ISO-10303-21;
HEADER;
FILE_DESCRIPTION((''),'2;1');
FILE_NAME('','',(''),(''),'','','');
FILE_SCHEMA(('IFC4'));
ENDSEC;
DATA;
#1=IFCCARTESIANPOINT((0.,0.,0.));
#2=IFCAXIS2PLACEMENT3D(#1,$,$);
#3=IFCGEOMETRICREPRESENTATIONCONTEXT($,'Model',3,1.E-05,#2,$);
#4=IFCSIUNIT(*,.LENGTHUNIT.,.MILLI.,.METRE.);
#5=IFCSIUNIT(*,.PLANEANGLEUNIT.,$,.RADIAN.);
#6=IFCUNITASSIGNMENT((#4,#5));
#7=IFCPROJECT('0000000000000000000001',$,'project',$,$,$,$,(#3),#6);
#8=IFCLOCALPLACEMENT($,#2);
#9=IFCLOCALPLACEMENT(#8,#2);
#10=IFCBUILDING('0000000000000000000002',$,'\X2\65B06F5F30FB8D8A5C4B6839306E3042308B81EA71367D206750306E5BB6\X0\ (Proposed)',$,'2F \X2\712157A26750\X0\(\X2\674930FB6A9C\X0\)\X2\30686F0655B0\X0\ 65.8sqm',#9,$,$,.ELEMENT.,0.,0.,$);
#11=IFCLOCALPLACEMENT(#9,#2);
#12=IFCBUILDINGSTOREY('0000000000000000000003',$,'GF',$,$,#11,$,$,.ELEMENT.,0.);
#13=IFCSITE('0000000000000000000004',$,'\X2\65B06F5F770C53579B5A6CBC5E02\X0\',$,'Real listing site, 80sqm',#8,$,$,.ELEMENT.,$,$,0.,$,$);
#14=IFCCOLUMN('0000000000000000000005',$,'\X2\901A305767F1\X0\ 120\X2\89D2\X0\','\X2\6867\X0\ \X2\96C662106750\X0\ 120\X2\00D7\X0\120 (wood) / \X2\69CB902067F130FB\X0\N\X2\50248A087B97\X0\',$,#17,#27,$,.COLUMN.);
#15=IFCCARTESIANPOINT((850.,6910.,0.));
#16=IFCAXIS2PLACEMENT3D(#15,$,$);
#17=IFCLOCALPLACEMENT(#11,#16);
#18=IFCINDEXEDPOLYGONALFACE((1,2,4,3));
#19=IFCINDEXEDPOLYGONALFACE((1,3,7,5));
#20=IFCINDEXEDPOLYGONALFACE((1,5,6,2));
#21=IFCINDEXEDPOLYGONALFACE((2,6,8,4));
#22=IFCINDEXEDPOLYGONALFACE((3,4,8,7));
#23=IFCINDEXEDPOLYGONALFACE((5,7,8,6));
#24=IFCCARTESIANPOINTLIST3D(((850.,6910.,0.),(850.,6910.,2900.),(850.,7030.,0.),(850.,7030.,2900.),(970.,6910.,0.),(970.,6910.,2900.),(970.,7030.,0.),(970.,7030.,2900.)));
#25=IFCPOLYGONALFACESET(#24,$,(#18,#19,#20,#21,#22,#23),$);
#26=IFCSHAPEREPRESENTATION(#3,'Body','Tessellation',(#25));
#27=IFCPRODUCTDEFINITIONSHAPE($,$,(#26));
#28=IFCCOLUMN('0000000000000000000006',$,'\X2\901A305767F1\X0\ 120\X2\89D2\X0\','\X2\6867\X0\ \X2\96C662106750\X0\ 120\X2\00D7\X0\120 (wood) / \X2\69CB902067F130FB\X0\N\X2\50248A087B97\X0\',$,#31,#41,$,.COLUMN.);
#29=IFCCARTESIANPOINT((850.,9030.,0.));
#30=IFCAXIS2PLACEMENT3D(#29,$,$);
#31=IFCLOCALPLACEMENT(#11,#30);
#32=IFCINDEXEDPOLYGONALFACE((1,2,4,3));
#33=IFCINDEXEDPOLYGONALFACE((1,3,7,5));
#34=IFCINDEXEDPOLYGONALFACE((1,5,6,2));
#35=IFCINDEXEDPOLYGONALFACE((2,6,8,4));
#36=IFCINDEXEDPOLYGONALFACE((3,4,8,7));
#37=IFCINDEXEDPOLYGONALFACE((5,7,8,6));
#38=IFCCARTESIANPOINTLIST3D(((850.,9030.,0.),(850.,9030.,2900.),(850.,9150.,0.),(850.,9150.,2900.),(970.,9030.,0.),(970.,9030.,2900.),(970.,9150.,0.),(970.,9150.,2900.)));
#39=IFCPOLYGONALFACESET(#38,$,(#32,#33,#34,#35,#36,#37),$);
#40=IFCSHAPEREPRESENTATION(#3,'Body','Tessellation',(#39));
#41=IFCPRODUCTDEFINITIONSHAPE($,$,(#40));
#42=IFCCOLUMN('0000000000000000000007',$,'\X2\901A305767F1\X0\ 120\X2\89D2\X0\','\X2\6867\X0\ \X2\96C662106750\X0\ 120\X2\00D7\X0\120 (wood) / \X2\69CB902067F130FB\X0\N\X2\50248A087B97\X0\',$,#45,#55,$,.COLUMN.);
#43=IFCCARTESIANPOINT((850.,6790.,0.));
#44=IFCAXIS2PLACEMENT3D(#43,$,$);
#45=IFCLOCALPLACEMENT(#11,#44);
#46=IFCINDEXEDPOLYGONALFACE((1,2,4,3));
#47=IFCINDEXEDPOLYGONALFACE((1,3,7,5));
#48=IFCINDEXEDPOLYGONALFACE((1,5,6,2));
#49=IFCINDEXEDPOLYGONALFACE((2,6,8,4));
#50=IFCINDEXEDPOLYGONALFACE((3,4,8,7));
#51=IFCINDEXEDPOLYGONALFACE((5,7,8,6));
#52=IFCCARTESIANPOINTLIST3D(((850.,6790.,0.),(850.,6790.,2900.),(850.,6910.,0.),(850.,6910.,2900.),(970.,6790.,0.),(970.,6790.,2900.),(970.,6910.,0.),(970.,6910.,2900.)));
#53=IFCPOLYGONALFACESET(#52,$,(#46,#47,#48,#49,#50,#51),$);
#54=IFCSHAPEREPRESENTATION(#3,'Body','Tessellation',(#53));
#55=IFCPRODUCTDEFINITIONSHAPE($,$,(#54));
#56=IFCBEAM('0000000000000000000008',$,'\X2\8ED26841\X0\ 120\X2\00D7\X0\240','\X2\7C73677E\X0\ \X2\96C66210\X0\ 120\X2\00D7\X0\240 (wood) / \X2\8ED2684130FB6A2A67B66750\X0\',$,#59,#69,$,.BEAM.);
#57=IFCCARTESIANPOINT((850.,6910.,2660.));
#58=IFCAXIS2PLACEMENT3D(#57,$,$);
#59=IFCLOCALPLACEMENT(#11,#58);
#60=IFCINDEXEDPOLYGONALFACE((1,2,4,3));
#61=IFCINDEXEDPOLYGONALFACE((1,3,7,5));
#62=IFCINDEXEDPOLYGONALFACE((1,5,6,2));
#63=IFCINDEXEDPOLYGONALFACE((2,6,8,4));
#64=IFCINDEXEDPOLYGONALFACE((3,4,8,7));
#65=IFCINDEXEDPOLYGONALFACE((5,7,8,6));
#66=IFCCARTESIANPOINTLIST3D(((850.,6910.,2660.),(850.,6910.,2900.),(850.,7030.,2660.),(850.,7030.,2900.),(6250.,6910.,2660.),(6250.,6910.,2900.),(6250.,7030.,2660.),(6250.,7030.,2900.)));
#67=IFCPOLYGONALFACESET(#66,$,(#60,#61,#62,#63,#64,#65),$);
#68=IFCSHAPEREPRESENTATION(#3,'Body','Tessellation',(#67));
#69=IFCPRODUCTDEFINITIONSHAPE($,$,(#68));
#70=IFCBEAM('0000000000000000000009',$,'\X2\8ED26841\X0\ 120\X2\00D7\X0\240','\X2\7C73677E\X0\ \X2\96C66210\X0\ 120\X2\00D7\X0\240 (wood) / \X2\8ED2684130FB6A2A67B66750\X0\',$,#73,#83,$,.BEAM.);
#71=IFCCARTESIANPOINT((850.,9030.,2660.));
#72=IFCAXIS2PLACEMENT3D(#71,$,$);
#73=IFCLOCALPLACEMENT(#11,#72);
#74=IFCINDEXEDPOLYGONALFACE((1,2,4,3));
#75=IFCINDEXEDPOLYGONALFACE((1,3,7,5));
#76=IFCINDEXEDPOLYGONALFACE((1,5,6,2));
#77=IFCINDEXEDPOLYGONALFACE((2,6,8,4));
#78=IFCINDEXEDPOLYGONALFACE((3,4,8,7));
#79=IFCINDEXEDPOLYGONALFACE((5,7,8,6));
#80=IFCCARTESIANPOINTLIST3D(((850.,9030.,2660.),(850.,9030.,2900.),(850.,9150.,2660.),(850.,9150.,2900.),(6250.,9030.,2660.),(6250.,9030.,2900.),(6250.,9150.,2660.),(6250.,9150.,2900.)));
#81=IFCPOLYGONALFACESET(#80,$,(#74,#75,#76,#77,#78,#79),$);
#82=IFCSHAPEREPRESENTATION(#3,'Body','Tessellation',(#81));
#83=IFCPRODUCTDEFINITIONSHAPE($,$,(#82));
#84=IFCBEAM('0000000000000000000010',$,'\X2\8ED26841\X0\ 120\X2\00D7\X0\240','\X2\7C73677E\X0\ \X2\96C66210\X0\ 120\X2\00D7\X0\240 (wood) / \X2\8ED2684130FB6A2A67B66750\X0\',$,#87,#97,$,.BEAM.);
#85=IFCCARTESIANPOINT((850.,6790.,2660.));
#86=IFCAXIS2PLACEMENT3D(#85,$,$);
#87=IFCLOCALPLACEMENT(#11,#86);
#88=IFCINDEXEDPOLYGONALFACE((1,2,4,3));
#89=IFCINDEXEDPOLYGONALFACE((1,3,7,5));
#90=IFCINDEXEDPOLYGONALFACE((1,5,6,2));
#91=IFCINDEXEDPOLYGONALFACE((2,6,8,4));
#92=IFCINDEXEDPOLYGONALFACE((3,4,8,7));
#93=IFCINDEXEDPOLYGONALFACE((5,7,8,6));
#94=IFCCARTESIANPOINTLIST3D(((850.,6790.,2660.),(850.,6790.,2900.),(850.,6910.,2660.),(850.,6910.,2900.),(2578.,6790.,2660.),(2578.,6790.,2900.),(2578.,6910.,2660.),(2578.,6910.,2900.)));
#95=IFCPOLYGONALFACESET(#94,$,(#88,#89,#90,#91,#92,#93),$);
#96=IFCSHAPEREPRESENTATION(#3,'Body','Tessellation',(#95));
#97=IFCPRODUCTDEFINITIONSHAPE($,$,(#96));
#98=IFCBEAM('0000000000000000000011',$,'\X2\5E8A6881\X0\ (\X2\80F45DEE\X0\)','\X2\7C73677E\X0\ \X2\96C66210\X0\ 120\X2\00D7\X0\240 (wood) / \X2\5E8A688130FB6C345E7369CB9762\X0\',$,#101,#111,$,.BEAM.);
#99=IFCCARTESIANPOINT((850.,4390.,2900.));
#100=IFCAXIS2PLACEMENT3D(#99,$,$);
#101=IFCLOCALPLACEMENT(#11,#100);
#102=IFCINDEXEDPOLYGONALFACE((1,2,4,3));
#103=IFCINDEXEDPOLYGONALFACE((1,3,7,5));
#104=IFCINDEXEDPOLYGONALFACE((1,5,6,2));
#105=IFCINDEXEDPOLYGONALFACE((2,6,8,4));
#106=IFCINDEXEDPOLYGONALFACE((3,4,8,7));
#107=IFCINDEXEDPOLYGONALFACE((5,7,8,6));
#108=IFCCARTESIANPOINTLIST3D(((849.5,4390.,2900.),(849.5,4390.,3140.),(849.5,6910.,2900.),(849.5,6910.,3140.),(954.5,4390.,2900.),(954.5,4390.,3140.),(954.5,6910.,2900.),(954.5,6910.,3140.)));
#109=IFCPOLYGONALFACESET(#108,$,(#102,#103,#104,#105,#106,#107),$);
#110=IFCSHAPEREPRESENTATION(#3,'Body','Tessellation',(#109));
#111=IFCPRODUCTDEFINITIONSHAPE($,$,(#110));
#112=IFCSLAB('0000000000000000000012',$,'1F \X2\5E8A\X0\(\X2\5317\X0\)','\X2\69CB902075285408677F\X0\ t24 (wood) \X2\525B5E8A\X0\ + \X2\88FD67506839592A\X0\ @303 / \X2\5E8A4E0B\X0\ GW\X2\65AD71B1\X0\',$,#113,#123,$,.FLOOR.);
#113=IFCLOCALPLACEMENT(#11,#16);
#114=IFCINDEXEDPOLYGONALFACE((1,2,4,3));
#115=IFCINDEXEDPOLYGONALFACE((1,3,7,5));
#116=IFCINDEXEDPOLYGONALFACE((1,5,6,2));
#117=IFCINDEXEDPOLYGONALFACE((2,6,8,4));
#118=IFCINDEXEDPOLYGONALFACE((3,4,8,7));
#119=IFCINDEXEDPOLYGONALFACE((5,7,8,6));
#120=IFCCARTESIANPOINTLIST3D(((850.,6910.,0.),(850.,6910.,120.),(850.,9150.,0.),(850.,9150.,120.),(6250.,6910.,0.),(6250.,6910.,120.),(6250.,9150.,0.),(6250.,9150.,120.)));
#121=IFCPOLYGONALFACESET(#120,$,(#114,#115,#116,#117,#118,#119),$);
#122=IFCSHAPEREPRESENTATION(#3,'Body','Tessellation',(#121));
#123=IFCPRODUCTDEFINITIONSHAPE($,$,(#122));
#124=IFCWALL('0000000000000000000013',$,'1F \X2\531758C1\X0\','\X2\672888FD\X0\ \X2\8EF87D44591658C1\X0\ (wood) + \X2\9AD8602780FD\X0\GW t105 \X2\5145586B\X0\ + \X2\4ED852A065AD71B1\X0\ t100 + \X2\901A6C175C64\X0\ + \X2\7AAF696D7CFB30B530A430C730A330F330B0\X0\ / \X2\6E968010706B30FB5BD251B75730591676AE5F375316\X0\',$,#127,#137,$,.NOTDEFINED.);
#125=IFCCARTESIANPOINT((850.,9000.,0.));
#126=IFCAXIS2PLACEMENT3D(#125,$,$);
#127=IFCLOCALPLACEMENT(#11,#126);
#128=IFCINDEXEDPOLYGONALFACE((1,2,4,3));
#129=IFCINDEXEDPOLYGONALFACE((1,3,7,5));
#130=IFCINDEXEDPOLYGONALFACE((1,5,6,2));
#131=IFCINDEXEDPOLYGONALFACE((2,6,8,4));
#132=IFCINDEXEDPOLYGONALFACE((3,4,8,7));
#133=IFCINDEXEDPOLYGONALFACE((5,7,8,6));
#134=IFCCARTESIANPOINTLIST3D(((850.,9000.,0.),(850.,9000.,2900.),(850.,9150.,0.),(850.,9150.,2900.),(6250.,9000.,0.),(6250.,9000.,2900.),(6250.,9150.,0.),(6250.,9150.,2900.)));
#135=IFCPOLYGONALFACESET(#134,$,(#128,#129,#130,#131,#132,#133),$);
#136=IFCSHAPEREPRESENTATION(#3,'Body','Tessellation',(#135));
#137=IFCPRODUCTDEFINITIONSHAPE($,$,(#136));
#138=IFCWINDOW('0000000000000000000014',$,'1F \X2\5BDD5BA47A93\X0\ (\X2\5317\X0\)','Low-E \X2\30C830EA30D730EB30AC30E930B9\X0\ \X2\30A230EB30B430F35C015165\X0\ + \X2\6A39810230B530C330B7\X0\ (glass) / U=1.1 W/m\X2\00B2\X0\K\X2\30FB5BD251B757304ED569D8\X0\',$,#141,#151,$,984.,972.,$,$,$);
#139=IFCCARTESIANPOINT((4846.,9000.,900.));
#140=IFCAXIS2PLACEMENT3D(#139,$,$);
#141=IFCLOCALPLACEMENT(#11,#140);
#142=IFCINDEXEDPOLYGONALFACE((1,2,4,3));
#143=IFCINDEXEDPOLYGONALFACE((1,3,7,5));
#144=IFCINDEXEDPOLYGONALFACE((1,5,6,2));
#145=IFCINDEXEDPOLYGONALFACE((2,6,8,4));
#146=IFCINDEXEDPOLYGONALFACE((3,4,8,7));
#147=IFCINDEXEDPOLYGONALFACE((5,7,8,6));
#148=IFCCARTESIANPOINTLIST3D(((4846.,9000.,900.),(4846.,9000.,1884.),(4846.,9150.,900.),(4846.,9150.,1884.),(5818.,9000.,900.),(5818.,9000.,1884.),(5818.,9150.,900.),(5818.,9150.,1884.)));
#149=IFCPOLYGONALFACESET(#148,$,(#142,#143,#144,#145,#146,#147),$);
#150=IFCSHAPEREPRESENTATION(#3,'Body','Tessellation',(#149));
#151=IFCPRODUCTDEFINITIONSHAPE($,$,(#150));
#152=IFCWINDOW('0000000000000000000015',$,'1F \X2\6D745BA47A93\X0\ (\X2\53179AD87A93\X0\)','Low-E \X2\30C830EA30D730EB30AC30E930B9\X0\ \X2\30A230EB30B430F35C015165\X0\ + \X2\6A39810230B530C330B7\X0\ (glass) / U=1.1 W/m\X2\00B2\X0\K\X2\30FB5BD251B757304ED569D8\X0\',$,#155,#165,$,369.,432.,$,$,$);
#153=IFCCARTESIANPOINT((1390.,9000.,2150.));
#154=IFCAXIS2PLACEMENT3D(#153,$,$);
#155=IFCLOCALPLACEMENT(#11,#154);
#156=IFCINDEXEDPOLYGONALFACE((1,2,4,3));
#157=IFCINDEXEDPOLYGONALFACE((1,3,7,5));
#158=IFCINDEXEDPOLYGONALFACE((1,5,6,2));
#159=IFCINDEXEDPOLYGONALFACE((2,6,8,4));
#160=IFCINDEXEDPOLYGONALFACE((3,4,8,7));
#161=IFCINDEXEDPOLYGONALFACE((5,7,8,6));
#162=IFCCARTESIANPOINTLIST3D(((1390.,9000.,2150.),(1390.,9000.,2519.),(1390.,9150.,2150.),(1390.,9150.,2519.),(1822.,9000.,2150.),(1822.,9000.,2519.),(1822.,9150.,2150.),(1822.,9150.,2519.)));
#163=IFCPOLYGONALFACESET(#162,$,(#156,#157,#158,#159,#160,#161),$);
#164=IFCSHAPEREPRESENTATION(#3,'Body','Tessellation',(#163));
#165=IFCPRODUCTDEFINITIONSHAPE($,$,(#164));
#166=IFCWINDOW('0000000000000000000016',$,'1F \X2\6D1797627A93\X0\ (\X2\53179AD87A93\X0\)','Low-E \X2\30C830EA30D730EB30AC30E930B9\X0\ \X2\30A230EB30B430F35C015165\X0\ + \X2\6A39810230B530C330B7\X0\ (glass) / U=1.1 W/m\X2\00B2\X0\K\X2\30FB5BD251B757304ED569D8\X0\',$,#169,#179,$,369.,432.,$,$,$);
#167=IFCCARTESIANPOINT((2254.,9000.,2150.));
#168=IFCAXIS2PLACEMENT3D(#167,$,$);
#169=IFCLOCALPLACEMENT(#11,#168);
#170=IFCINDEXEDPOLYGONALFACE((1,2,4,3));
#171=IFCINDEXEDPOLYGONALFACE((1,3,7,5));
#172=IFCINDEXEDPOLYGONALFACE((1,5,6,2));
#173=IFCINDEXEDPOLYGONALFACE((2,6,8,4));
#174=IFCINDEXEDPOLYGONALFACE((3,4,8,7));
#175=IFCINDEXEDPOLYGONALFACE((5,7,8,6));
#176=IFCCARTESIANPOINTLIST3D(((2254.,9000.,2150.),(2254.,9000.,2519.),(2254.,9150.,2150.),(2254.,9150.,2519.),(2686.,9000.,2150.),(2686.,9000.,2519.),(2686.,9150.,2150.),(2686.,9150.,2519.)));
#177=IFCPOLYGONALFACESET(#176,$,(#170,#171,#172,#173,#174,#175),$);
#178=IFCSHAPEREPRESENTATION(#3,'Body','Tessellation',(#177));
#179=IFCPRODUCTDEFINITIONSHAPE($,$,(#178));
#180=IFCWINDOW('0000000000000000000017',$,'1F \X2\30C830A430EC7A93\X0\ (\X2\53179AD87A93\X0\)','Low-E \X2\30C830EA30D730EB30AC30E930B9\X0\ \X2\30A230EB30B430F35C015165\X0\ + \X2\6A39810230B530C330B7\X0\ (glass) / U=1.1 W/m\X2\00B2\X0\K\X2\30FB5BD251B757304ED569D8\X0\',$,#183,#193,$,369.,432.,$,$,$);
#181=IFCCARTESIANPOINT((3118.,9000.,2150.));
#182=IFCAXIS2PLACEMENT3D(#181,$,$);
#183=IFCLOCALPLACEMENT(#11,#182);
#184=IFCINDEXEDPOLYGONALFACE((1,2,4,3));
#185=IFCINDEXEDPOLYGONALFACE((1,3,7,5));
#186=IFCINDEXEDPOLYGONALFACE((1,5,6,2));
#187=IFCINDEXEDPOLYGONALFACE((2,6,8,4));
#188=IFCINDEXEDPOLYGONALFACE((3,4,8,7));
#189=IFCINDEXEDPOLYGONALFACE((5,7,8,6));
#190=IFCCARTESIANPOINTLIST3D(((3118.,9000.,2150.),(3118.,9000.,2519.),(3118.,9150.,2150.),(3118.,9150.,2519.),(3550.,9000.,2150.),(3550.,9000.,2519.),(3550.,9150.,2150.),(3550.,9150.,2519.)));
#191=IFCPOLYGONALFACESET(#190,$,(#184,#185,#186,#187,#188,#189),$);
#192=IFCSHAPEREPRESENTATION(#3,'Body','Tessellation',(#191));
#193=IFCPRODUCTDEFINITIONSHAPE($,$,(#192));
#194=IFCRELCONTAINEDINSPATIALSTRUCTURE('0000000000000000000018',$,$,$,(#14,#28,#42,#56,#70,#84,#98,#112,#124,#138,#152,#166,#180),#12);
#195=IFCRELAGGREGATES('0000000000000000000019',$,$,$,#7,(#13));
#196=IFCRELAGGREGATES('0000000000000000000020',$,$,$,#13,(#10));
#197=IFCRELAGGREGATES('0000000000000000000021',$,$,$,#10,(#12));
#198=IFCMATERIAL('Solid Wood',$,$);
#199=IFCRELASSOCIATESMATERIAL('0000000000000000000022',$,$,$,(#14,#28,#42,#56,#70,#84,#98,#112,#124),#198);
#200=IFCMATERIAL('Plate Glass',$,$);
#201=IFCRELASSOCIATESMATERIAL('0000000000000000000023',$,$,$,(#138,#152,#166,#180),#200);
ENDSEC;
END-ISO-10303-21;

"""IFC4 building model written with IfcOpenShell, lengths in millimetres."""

from ifc_helpers import new_model, si_unit, frame, frame_2d, origin, place, context, project, spatial, rectangle, extrude, material, element, fill, save


model = new_model("IFC4")

# Units and contexts
model_context = context("Model", 3, precision=1e-05, world=origin())
ifc_project = project(units=[si_unit("LENGTHUNIT", "METRE", prefix="MILLI"), si_unit("PLANEANGLEUNIT", "RADIAN")], contexts=[model_context])

# Site, building, storey
site_placement = place(None, origin())
site = spatial("IfcSite", under=ifc_project, at=site_placement, Name="新潟県南魚沼市", ObjectType="Real listing site, 80sqm", CompositionType="ELEMENT", RefElevation=0.0)
building_placement = place(site_placement, origin())
building = spatial("IfcBuilding", under=site, at=building_placement, Name="新潟・越屋根のある自然素材の家 (Proposed)", ObjectType="2F 無垢材(杉・檜)と漆喰 65.8sqm", CompositionType="ELEMENT", ElevationOfRefHeight=0.0, ElevationOfTerrain=0.0)
storey_placement = place(building_placement, origin())
storey = spatial("IfcBuildingStorey", under=building, at=storey_placement, Name="GF", CompositionType="ELEMENT", Elevation=0.0)

# Columns
ifc_material_1 = material(Name="Solid Wood")
column_1_placement = place(storey_placement, frame((850.0, 6910.0, 0.0)))
element("IfcColumn", 1, at=column_1_placement, inside=storey, material=ifc_material_1, Name="通し柱 120角", Description="桧 集成材 120×120 (wood) / 構造柱・N値計算", PredefinedType="COLUMN", context=model_context, shape_type="SweptSolid", body=[
    extrude(rectangle(XDim=120.0, YDim=120.0, at=frame_2d((60.0, 60.0))), frame((850.0, 6910.0, 0.0)), (0.0, 0.0, 1.0), 2900.0),
])
column_2_placement = place(storey_placement, frame((850.0, 9030.0, 0.0)))
element("IfcColumn", 2, at=column_2_placement, inside=storey, material=ifc_material_1, Name="通し柱 120角", Description="桧 集成材 120×120 (wood) / 構造柱・N値計算", PredefinedType="COLUMN", context=model_context, shape_type="SweptSolid", body=[
    extrude(rectangle(XDim=120.0, YDim=120.0, at=frame_2d((60.0, 60.0))), frame((850.0, 9030.0, 0.0)), (0.0, 0.0, 1.0), 2900.0),
])
column_3_placement = place(storey_placement, frame((850.0, 6790.0, 0.0)))
element("IfcColumn", 3, at=column_3_placement, inside=storey, material=ifc_material_1, Name="通し柱 120角", Description="桧 集成材 120×120 (wood) / 構造柱・N値計算", PredefinedType="COLUMN", context=model_context, shape_type="SweptSolid", body=[
    extrude(rectangle(XDim=120.0, YDim=120.0, at=frame_2d((60.0, 60.0))), frame((850.0, 6790.0, 0.0)), (0.0, 0.0, 1.0), 2900.0),
])

# Beams
beam_1_placement = place(storey_placement, frame((850.0, 6910.0, 2660.0)))
element("IfcBeam", 4, at=beam_1_placement, inside=storey, material=ifc_material_1, Name="軒桁 120×240", Description="米松 集成 120×240 (wood) / 軒桁・横架材", PredefinedType="BEAM", context=model_context, shape_type="SweptSolid", body=[
    extrude(rectangle(XDim=5400.0, YDim=120.0, at=frame_2d((2700.0, 60.0))), frame((850.0, 6910.0, 2660.0)), (0.0, 0.0, 1.0), 240.0),
])
beam_2_placement = place(storey_placement, frame((850.0, 9030.0, 2660.0)))
element("IfcBeam", 5, at=beam_2_placement, inside=storey, material=ifc_material_1, Name="軒桁 120×240", Description="米松 集成 120×240 (wood) / 軒桁・横架材", PredefinedType="BEAM", context=model_context, shape_type="SweptSolid", body=[
    extrude(rectangle(XDim=5400.0, YDim=120.0, at=frame_2d((2700.0, 60.0))), frame((850.0, 9030.0, 2660.0)), (0.0, 0.0, 1.0), 240.0),
])
beam_3_placement = place(storey_placement, frame((850.0, 6790.0, 2660.0)))
element("IfcBeam", 6, at=beam_3_placement, inside=storey, material=ifc_material_1, Name="軒桁 120×240", Description="米松 集成 120×240 (wood) / 軒桁・横架材", PredefinedType="BEAM", context=model_context, shape_type="SweptSolid", body=[
    extrude(rectangle(XDim=1728.0, YDim=120.0, at=frame_2d((864.0, 60.0))), frame((850.0, 6790.0, 2660.0)), (0.0, 0.0, 1.0), 240.0),
])
beam_4_placement = place(storey_placement, frame((850.0, 4390.0, 2900.0)))
element("IfcBeam", 7, at=beam_4_placement, inside=storey, material=ifc_material_1, Name="床梁 (胴差)", Description="米松 集成 120×240 (wood) / 床梁・水平構面", PredefinedType="BEAM", context=model_context, shape_type="SweptSolid", body=[
    extrude(rectangle(XDim=105.0, YDim=2520.0, at=frame_2d((52.0, 1260.0))), frame((850.0, 4390.0, 2900.0)), (0.0, 0.0, 1.0), 240.0),
])

# Slab
slab_placement = place(storey_placement, frame((850.0, 6910.0, 0.0)))
element("IfcSlab", 8, at=slab_placement, inside=storey, material=ifc_material_1, Name="1F 床(北)", Description="構造用合板 t24 (wood) 剛床 + 製材根太 @303 / 床下 GW断熱", PredefinedType="FLOOR", context=model_context, shape_type="SweptSolid", body=[
    extrude(rectangle(XDim=5400.0, YDim=2240.0, at=frame_2d((2700.0, 1120.0))), frame((850.0, 6910.0, 0.0)), (0.0, 0.0, 1.0), 120.0),
])

# Wall, openings, windows
wall_1_placement = place(storey_placement, frame((850.0, 9000.0, 0.0)))
wall_1 = element("IfcWall", 9, at=wall_1_placement, inside=storey, material=ifc_material_1, Name="1F 北壁", Description="木製 軸組外壁 (wood) + 高性能GW t105 充填 + 付加断熱 t100 + 通気層 + 窯業系サイディング / 準耐火・寒冷地外皮強化", PredefinedType="NOTDEFINED", context=model_context, shape_type="SweptSolid", body=[
    extrude(rectangle(XDim=5400.0, YDim=150.0, at=frame_2d((2700.0, 75.0))), frame((850.0, 9000.0, 0.0)), (0.0, 0.0, 1.0), 2900.0),
])
opening_1_placement = place(storey_placement, frame((4846.0, 9000.0, 900.0)))
opening_1 = element("IfcOpeningElement", 10, at=opening_1_placement, cuts=wall_1, PredefinedType="NOTDEFINED", context=model_context, shape_type="SweptSolid", body=[
    extrude(rectangle(XDim=972.0, YDim=150.0, at=frame_2d((486.0, 75.0))), frame((4846.0, 9000.0, 900.0)), (0.0, 0.0, 1.0), 984.0),
])
opening_2_placement = place(storey_placement, frame((1390.0, 9000.0, 2150.0)))
opening_2 = element("IfcOpeningElement", 11, at=opening_2_placement, cuts=wall_1, PredefinedType="NOTDEFINED", context=model_context, shape_type="SweptSolid", body=[
    extrude(rectangle(XDim=432.0, YDim=150.0, at=frame_2d((216.0, 75.0))), frame((1390.0, 9000.0, 2150.0)), (0.0, 0.0, 1.0), 369.0),
])
opening_3_placement = place(storey_placement, frame((2254.0, 9000.0, 2150.0)))
opening_3 = element("IfcOpeningElement", 12, at=opening_3_placement, cuts=wall_1, PredefinedType="NOTDEFINED", context=model_context, shape_type="SweptSolid", body=[
    extrude(rectangle(XDim=432.0, YDim=150.0, at=frame_2d((216.0, 75.0))), frame((2254.0, 9000.0, 2150.0)), (0.0, 0.0, 1.0), 369.0),
])
opening_4_placement = place(storey_placement, frame((3118.0, 9000.0, 2150.0)))
opening_4 = element("IfcOpeningElement", 13, at=opening_4_placement, cuts=wall_1, PredefinedType="NOTDEFINED", context=model_context, shape_type="SweptSolid", body=[
    extrude(rectangle(XDim=432.0, YDim=150.0, at=frame_2d((216.0, 75.0))), frame((3118.0, 9000.0, 2150.0)), (0.0, 0.0, 1.0), 369.0),
])
ifc_material_2 = material(Name="Plate Glass")
window_1_placement = place(storey_placement, frame((4846.0, 9000.0, 900.0)))
window_1 = element("IfcWindow", 14, at=window_1_placement, inside=storey, material=ifc_material_2, Name="1F 寝室窓 (北)", Description="Low-E トリプルガラス アルゴン封入 + 樹脂サッシ (glass) / U=1.1 W/m²K・寒冷地仕様", OverallHeight=984.0, OverallWidth=972.0, context=model_context, shape_type="SweptSolid", body=[
    extrude(rectangle(XDim=972.0, YDim=150.0, at=frame_2d((486.0, 75.0))), frame((4846.0, 9000.0, 900.0)), (0.0, 0.0, 1.0), 984.0),
])
fill(opening_1, window_1)
window_2_placement = place(storey_placement, frame((1390.0, 9000.0, 2150.0)))
window_2 = element("IfcWindow", 15, at=window_2_placement, inside=storey, material=ifc_material_2, Name="1F 浴室窓 (北高窓)", Description="Low-E トリプルガラス アルゴン封入 + 樹脂サッシ (glass) / U=1.1 W/m²K・寒冷地仕様", OverallHeight=369.0, OverallWidth=432.0, context=model_context, shape_type="SweptSolid", body=[
    extrude(rectangle(XDim=432.0, YDim=150.0, at=frame_2d((216.0, 75.0))), frame((1390.0, 9000.0, 2150.0)), (0.0, 0.0, 1.0), 369.0),
])
fill(opening_2, window_2)
window_3_placement = place(storey_placement, frame((2254.0, 9000.0, 2150.0)))
window_3 = element("IfcWindow", 16, at=window_3_placement, inside=storey, material=ifc_material_2, Name="1F 洗面窓 (北高窓)", Description="Low-E トリプルガラス アルゴン封入 + 樹脂サッシ (glass) / U=1.1 W/m²K・寒冷地仕様", OverallHeight=369.0, OverallWidth=432.0, context=model_context, shape_type="SweptSolid", body=[
    extrude(rectangle(XDim=432.0, YDim=150.0, at=frame_2d((216.0, 75.0))), frame((2254.0, 9000.0, 2150.0)), (0.0, 0.0, 1.0), 369.0),
])
fill(opening_3, window_3)
window_4_placement = place(storey_placement, frame((3118.0, 9000.0, 2150.0)))
window_4 = element("IfcWindow", 17, at=window_4_placement, inside=storey, material=ifc_material_2, Name="1F トイレ窓 (北高窓)", Description="Low-E トリプルガラス アルゴン封入 + 樹脂サッシ (glass) / U=1.1 W/m²K・寒冷地仕様", OverallHeight=369.0, OverallWidth=432.0, context=model_context, shape_type="SweptSolid", body=[
    extrude(rectangle(XDim=432.0, YDim=150.0, at=frame_2d((216.0, 75.0))), frame((3118.0, 9000.0, 2150.0)), (0.0, 0.0, 1.0), 369.0),
])
fill(opening_4, window_4)

save(model, "model.ifc")
